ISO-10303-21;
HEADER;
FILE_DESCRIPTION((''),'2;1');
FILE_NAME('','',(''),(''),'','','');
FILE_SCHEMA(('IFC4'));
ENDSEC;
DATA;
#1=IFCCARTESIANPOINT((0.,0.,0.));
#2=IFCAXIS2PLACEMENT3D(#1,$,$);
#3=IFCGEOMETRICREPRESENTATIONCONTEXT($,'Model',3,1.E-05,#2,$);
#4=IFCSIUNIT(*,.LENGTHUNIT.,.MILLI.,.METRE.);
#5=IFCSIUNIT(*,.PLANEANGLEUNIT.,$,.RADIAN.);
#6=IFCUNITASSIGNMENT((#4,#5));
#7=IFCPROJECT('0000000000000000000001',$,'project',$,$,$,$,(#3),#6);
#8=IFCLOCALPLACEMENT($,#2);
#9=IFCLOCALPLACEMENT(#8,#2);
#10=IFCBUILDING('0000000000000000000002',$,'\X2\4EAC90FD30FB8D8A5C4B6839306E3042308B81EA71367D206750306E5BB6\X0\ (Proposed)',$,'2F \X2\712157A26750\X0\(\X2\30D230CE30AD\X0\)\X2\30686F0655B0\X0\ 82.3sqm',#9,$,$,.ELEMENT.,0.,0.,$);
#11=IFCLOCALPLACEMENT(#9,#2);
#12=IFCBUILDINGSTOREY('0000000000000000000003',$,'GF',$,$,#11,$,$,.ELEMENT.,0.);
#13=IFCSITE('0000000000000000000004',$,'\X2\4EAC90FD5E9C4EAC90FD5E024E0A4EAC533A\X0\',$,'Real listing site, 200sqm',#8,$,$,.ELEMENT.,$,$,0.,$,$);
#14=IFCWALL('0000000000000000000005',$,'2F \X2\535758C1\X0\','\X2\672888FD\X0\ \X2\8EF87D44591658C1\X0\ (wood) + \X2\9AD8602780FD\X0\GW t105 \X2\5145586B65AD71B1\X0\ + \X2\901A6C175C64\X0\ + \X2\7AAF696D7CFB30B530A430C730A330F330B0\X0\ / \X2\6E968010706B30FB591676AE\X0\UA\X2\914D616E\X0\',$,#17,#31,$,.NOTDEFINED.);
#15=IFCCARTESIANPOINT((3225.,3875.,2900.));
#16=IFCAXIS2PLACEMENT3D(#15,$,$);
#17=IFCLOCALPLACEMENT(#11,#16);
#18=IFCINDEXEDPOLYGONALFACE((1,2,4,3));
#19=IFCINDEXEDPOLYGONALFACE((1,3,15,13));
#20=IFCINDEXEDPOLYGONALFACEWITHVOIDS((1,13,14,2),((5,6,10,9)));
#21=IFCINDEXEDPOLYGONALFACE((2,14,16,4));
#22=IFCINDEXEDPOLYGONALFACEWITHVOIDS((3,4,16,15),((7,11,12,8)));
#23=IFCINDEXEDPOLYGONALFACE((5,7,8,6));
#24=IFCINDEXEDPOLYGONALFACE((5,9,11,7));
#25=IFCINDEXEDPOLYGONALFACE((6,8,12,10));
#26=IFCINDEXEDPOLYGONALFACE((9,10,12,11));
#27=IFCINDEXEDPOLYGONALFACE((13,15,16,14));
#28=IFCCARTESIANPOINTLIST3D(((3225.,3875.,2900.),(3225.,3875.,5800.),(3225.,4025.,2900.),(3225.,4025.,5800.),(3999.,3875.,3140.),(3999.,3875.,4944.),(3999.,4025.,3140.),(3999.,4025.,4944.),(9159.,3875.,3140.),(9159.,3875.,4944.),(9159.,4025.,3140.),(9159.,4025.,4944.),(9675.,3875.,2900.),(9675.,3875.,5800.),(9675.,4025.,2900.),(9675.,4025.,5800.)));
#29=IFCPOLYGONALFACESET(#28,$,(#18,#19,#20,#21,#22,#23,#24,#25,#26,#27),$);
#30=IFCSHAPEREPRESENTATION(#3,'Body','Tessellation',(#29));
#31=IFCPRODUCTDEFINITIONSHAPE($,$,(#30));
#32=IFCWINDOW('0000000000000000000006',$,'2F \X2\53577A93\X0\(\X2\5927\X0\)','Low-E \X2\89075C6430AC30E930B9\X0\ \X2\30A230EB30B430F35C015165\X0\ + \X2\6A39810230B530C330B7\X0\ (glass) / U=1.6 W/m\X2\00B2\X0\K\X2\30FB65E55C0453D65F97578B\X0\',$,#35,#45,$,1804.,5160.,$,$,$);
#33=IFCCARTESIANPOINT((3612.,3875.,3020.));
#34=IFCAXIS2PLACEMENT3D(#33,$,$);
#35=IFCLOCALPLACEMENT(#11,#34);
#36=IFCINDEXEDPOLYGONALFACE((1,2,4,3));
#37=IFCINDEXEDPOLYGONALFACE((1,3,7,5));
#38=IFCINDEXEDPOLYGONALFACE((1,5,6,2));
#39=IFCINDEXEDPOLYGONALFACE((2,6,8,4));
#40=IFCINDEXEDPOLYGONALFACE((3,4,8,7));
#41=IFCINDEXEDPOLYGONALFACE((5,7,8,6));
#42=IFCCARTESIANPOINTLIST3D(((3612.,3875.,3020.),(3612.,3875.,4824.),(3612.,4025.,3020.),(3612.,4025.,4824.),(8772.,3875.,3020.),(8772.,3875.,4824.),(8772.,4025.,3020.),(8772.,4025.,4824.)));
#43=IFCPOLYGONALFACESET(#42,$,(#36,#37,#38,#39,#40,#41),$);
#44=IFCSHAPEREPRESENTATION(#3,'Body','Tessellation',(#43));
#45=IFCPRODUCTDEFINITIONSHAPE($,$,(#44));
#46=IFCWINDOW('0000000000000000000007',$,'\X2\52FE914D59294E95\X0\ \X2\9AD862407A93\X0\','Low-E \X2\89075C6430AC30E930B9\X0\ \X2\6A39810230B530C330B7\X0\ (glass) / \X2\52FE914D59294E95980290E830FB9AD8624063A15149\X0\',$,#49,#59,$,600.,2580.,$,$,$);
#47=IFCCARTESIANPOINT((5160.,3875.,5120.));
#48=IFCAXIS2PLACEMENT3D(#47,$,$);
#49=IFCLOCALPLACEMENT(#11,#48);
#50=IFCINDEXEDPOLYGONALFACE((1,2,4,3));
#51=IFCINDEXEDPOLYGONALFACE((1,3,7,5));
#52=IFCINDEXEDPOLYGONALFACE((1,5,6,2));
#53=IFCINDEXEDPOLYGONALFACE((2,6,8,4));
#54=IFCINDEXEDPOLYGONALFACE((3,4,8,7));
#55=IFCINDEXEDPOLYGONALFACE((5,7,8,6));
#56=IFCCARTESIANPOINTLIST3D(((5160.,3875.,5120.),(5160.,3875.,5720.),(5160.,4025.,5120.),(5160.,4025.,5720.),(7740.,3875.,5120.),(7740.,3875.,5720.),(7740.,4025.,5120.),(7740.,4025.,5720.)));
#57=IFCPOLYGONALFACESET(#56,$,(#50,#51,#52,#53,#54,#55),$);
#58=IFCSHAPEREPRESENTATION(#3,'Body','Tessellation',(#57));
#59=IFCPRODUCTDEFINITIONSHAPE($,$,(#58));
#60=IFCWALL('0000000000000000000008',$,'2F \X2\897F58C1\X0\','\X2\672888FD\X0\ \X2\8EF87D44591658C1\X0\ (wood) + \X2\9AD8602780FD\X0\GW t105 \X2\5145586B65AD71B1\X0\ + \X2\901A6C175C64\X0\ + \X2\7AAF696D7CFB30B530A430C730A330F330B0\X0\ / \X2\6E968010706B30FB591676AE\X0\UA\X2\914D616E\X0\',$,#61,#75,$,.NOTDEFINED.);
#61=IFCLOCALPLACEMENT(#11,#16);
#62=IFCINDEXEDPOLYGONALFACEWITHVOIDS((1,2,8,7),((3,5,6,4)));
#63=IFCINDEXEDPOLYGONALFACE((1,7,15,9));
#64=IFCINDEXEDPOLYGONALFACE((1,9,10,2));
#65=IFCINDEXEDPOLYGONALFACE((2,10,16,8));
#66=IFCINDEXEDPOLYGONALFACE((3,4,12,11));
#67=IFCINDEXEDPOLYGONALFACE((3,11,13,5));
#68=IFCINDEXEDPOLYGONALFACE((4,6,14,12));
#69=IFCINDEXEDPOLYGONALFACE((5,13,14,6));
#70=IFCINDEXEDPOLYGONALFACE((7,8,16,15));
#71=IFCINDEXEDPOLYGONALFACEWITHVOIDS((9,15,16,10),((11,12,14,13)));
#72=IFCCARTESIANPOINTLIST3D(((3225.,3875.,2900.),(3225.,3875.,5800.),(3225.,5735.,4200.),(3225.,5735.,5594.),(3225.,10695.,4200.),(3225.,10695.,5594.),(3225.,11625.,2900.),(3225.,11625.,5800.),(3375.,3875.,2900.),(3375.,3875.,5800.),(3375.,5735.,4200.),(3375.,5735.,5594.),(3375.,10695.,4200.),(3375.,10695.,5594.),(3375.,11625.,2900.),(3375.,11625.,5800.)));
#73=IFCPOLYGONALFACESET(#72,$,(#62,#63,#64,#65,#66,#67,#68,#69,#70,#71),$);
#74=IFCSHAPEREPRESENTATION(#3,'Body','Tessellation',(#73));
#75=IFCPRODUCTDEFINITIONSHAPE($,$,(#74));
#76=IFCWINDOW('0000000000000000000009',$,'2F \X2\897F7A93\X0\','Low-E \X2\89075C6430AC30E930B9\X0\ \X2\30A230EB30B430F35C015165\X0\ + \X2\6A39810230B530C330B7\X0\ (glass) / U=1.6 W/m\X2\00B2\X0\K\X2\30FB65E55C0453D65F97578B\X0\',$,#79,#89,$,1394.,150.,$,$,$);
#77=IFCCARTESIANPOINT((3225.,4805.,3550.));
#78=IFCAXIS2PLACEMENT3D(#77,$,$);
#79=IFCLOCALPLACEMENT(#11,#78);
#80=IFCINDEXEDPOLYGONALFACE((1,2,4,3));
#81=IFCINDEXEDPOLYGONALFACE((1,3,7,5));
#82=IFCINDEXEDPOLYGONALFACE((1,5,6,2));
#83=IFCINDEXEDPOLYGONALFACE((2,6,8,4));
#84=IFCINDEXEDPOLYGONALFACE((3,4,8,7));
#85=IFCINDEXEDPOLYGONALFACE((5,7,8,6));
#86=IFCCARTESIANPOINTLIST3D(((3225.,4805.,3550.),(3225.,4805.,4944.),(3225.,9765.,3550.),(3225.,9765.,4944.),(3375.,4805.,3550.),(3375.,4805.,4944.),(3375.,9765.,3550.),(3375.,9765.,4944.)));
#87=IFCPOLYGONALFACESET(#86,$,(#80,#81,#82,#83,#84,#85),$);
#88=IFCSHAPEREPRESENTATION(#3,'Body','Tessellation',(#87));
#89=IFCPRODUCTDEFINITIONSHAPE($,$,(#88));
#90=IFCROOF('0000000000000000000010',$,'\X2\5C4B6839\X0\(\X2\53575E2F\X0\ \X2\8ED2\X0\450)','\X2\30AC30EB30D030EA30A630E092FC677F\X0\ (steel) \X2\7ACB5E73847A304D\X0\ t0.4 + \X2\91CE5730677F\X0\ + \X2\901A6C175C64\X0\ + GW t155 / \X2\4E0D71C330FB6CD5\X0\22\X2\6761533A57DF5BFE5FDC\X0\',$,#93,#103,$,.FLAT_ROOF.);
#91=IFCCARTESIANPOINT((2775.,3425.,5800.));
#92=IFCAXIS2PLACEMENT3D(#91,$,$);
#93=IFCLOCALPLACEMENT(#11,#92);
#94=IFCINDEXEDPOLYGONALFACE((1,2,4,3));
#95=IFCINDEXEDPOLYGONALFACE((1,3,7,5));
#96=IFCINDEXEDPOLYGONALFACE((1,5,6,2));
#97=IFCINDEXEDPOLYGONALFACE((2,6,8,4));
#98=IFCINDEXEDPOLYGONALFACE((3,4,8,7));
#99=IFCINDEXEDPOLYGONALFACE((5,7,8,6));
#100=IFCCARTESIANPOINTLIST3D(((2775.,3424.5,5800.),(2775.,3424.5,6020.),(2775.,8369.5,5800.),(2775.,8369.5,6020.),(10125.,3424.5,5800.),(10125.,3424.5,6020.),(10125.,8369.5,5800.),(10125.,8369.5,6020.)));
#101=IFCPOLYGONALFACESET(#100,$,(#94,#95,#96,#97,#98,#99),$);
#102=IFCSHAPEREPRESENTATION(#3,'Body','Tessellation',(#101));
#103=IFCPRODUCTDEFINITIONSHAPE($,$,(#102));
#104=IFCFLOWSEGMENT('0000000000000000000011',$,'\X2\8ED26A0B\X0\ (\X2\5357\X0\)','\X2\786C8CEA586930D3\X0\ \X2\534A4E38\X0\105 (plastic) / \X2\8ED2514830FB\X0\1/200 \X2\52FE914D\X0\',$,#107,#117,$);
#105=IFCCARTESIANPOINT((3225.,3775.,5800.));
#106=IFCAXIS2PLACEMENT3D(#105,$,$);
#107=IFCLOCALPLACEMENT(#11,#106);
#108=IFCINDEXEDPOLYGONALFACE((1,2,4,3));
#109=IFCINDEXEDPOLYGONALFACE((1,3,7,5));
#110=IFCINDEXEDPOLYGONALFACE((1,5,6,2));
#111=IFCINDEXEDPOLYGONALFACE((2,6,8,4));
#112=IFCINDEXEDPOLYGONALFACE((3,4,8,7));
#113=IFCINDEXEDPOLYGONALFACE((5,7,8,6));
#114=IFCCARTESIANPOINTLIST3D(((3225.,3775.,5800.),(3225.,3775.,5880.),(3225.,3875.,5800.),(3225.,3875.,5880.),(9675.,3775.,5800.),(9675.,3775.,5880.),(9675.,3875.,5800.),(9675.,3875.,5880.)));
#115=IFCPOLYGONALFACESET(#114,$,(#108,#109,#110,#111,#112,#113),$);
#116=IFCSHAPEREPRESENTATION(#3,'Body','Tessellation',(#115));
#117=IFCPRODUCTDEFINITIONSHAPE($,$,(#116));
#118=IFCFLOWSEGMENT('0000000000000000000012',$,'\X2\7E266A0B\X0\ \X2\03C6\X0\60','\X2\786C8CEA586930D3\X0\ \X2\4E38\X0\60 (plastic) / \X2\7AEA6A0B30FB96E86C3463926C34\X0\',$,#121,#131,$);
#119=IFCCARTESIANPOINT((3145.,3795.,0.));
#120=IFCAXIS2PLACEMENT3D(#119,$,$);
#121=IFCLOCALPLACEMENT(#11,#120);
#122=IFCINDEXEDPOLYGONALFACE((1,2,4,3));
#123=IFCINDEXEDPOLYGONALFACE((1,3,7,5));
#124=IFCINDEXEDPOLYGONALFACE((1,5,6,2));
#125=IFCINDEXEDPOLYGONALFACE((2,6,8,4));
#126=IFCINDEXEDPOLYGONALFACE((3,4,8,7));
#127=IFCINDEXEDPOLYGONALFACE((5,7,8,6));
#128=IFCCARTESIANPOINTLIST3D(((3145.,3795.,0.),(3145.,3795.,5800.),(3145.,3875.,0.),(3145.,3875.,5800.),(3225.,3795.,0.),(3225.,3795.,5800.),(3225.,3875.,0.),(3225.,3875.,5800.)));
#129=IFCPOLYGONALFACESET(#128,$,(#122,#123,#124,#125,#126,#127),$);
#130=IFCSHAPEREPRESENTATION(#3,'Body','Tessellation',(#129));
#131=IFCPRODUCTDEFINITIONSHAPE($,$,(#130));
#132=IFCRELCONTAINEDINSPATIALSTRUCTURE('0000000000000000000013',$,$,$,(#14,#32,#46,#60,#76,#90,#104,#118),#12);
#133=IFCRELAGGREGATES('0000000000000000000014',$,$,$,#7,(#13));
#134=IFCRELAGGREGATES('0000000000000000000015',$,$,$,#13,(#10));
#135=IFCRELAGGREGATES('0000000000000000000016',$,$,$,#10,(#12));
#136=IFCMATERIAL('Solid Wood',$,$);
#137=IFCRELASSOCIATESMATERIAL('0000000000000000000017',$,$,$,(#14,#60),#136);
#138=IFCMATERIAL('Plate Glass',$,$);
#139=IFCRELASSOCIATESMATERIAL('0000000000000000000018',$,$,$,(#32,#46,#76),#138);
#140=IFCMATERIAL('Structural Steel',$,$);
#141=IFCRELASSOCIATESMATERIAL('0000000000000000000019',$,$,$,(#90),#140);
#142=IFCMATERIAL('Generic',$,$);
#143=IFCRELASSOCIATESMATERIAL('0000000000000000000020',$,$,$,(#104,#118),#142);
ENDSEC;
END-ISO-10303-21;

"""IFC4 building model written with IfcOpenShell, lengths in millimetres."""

from ifc_helpers import new_model, si_unit, frame, frame_2d, origin, place, context, project, spatial, rectangle, extrude, material, element, fill, save


model = new_model("IFC4")

# Units and contexts
model_context = context("Model", 3, precision=1e-05, world=origin())
ifc_project = project(units=[si_unit("LENGTHUNIT", "METRE", prefix="MILLI"), si_unit("PLANEANGLEUNIT", "RADIAN")], contexts=[model_context])

# Site, building, storey
site_placement = place(None, origin())
site = spatial("IfcSite", under=ifc_project, at=site_placement, Name="京都府京都市上京区", ObjectType="Real listing site, 200sqm", CompositionType="ELEMENT", RefElevation=0.0)
building_placement = place(site_placement, origin())
building = spatial("IfcBuilding", under=site, at=building_placement, Name="京都・越屋根のある自然素材の家 (Proposed)", ObjectType="2F 無垢材(ヒノキ)と漆喰 82.3sqm", CompositionType="ELEMENT", ElevationOfRefHeight=0.0, ElevationOfTerrain=0.0)
storey_placement = place(building_placement, origin())
storey = spatial("IfcBuildingStorey", under=building, at=storey_placement, Name="GF", CompositionType="ELEMENT", Elevation=0.0)

# Shared definitions
ifc_material_1 = material(Name="Solid Wood")

# Shared definitions
ifc_material_2 = material(Name="Plate Glass")

# Wall, openings, windows
wall_1_placement = place(storey_placement, frame((3225.0, 3875.0, 2900.0)))
wall_1 = element("IfcWall", 1, at=wall_1_placement, inside=storey, material=ifc_material_1, Name="2F 南壁", Description="木製 軸組外壁 (wood) + 高性能GW t105 充填断熱 + 通気層 + 窯業系サイディング / 準耐火・外皮UA配慮", PredefinedType="NOTDEFINED", context=model_context, shape_type="SweptSolid", body=[
    extrude(rectangle(XDim=6450.0, YDim=150.0, at=frame_2d((3225.0, 75.0))), frame((3225.0, 3875.0, 2900.0)), (0.0, 0.0, 1.0), 2900.0),
])
opening_1_placement = place(storey_placement, frame((3612.0, 3875.0, 3020.0)))
opening_1 = element("IfcOpeningElement", 2, at=opening_1_placement, cuts=wall_1, PredefinedType="NOTDEFINED", context=model_context, shape_type="SweptSolid", body=[
    extrude(rectangle(XDim=5160.0, YDim=150.0, at=frame_2d((2580.0, 75.0))), frame((3612.0, 3875.0, 3020.0)), (0.0, 0.0, 1.0), 1804.0),
])
opening_2_placement = place(storey_placement, frame((5160.0, 3875.0, 5120.0)))
opening_2 = element("IfcOpeningElement", 3, at=opening_2_placement, cuts=wall_1, PredefinedType="NOTDEFINED", context=model_context, shape_type="SweptSolid", body=[
    extrude(rectangle(XDim=2580.0, YDim=150.0, at=frame_2d((1290.0, 75.0))), frame((5160.0, 3875.0, 5120.0)), (0.0, 0.0, 1.0), 600.0),
])
window_1_placement = place(storey_placement, frame((3612.0, 3875.0, 3020.0)))
window_1 = element("IfcWindow", 4, at=window_1_placement, inside=storey, material=ifc_material_2, Name="2F 南窓(大)", Description="Low-E 複層ガラス アルゴン封入 + 樹脂サッシ (glass) / U=1.6 W/m²K・日射取得型", OverallHeight=1804.0, OverallWidth=5160.0, context=model_context, shape_type="SweptSolid", body=[
    extrude(rectangle(XDim=5160.0, YDim=150.0, at=frame_2d((2580.0, 75.0))), frame((3612.0, 3875.0, 3020.0)), (0.0, 0.0, 1.0), 1804.0),
])
fill(opening_1, window_1)
window_2_placement = place(storey_placement, frame((5160.0, 3875.0, 5120.0)))
window_2 = element("IfcWindow", 5, at=window_2_placement, inside=storey, material=ifc_material_2, Name="勾配天井 高所窓", Description="Low-E 複層ガラス 樹脂サッシ (glass) / 勾配天井頂部・高所採光", OverallHeight=600.0, OverallWidth=2580.0, context=model_context, shape_type="SweptSolid", body=[
    extrude(rectangle(XDim=2580.0, YDim=150.0, at=frame_2d((1290.0, 75.0))), frame((5160.0, 3875.0, 5120.0)), (0.0, 0.0, 1.0), 600.0),
])
fill(opening_2, window_2)

# Wall, opening, window
wall_2_placement = place(storey_placement, frame((3225.0, 3875.0, 2900.0)))
wall_2 = element("IfcWall", 6, at=wall_2_placement, inside=storey, material=ifc_material_1, Name="2F 西壁", Description="木製 軸組外壁 (wood) + 高性能GW t105 充填断熱 + 通気層 + 窯業系サイディング / 準耐火・外皮UA配慮", PredefinedType="NOTDEFINED", context=model_context, shape_type="SweptSolid", body=[
    extrude(rectangle(XDim=150.0, YDim=7750.0, at=frame_2d((75.0, 3875.0))), frame((3225.0, 3875.0, 2900.0)), (0.0, 0.0, 1.0), 2900.0),
])
opening_3_placement = place(storey_placement, frame((3225.0, 4805.0, 3550.0)))
opening_3 = element("IfcOpeningElement", 7, at=opening_3_placement, cuts=wall_2, PredefinedType="NOTDEFINED", context=model_context, shape_type="SweptSolid", body=[
    extrude(rectangle(XDim=150.0, YDim=4960.0, at=frame_2d((75.0, 2480.0))), frame((3225.0, 4805.0, 3550.0)), (0.0, 0.0, 1.0), 1394.0),
])
window_3_placement = place(storey_placement, frame((3225.0, 4805.0, 3550.0)))
window_3 = element("IfcWindow", 8, at=window_3_placement, inside=storey, material=ifc_material_2, Name="2F 西窓", Description="Low-E 複層ガラス アルゴン封入 + 樹脂サッシ (glass) / U=1.6 W/m²K・日射取得型", OverallHeight=1394.0, OverallWidth=150.0, context=model_context, shape_type="SweptSolid", body=[
    extrude(rectangle(XDim=150.0, YDim=4960.0, at=frame_2d((75.0, 2480.0))), frame((3225.0, 4805.0, 3550.0)), (0.0, 0.0, 1.0), 1394.0),
])
fill(opening_3, window_3)

# Roof
ifc_material_3 = material(Name="Structural Steel")
for number, where, name in (
    (9, (2775.0, 3425.0, 5800.0), "屋根(南帯 軒450)"),
):
    element("IfcRoof", number, at=place(storey_placement, frame(where)), inside=storey, material=ifc_material_3, Name=name, Description="ガルバリウム鋼板 (steel) 立平葺き t0.4 + 野地板 + 通気層 + GW t155 / 不燃・法22条区域対応", PredefinedType="FLAT_ROOF", context=model_context, shape_type="SweptSolid", body=[
        extrude(rectangle(XDim=7350.0, YDim=4945.0, at=frame_2d((3675.0, 2472.0))), frame((2775.0, 3425.0, 5800.0)), (0.0, 0.0, 1.0), 220.0),
    ])

# Flow segments
ifc_material_4 = material(Name="Generic")
flow_segment_1_placement = place(storey_placement, frame((3225.0, 3775.0, 5800.0)))
element("IfcFlowSegment", 10, at=flow_segment_1_placement, inside=storey, material=ifc_material_4, Name="軒樋 (南)", Description="硬質塩ビ 半丸105 (plastic) / 軒先・1/200 勾配", context=model_context, shape_type="SweptSolid", body=[
    extrude(rectangle(XDim=6450.0, YDim=100.0, at=frame_2d((3225.0, 50.0))), frame((3225.0, 3775.0, 5800.0)), (0.0, 0.0, 1.0), 80.0),
])
flow_segment_2_placement = place(storey_placement, frame((3145.0, 3795.0, 0.0)))
element("IfcFlowSegment", 11, at=flow_segment_2_placement, inside=storey, material=ifc_material_4, Name="縦樋 φ60", Description="硬質塩ビ 丸60 (plastic) / 竪樋・雨水排水", context=model_context, shape_type="SweptSolid", body=[
    extrude(rectangle(XDim=80.0, YDim=80.0, at=frame_2d((40.0, 40.0))), frame((3145.0, 3795.0, 0.0)), (0.0, 0.0, 1.0), 5800.0),
])

save(model, "model.ifc")
